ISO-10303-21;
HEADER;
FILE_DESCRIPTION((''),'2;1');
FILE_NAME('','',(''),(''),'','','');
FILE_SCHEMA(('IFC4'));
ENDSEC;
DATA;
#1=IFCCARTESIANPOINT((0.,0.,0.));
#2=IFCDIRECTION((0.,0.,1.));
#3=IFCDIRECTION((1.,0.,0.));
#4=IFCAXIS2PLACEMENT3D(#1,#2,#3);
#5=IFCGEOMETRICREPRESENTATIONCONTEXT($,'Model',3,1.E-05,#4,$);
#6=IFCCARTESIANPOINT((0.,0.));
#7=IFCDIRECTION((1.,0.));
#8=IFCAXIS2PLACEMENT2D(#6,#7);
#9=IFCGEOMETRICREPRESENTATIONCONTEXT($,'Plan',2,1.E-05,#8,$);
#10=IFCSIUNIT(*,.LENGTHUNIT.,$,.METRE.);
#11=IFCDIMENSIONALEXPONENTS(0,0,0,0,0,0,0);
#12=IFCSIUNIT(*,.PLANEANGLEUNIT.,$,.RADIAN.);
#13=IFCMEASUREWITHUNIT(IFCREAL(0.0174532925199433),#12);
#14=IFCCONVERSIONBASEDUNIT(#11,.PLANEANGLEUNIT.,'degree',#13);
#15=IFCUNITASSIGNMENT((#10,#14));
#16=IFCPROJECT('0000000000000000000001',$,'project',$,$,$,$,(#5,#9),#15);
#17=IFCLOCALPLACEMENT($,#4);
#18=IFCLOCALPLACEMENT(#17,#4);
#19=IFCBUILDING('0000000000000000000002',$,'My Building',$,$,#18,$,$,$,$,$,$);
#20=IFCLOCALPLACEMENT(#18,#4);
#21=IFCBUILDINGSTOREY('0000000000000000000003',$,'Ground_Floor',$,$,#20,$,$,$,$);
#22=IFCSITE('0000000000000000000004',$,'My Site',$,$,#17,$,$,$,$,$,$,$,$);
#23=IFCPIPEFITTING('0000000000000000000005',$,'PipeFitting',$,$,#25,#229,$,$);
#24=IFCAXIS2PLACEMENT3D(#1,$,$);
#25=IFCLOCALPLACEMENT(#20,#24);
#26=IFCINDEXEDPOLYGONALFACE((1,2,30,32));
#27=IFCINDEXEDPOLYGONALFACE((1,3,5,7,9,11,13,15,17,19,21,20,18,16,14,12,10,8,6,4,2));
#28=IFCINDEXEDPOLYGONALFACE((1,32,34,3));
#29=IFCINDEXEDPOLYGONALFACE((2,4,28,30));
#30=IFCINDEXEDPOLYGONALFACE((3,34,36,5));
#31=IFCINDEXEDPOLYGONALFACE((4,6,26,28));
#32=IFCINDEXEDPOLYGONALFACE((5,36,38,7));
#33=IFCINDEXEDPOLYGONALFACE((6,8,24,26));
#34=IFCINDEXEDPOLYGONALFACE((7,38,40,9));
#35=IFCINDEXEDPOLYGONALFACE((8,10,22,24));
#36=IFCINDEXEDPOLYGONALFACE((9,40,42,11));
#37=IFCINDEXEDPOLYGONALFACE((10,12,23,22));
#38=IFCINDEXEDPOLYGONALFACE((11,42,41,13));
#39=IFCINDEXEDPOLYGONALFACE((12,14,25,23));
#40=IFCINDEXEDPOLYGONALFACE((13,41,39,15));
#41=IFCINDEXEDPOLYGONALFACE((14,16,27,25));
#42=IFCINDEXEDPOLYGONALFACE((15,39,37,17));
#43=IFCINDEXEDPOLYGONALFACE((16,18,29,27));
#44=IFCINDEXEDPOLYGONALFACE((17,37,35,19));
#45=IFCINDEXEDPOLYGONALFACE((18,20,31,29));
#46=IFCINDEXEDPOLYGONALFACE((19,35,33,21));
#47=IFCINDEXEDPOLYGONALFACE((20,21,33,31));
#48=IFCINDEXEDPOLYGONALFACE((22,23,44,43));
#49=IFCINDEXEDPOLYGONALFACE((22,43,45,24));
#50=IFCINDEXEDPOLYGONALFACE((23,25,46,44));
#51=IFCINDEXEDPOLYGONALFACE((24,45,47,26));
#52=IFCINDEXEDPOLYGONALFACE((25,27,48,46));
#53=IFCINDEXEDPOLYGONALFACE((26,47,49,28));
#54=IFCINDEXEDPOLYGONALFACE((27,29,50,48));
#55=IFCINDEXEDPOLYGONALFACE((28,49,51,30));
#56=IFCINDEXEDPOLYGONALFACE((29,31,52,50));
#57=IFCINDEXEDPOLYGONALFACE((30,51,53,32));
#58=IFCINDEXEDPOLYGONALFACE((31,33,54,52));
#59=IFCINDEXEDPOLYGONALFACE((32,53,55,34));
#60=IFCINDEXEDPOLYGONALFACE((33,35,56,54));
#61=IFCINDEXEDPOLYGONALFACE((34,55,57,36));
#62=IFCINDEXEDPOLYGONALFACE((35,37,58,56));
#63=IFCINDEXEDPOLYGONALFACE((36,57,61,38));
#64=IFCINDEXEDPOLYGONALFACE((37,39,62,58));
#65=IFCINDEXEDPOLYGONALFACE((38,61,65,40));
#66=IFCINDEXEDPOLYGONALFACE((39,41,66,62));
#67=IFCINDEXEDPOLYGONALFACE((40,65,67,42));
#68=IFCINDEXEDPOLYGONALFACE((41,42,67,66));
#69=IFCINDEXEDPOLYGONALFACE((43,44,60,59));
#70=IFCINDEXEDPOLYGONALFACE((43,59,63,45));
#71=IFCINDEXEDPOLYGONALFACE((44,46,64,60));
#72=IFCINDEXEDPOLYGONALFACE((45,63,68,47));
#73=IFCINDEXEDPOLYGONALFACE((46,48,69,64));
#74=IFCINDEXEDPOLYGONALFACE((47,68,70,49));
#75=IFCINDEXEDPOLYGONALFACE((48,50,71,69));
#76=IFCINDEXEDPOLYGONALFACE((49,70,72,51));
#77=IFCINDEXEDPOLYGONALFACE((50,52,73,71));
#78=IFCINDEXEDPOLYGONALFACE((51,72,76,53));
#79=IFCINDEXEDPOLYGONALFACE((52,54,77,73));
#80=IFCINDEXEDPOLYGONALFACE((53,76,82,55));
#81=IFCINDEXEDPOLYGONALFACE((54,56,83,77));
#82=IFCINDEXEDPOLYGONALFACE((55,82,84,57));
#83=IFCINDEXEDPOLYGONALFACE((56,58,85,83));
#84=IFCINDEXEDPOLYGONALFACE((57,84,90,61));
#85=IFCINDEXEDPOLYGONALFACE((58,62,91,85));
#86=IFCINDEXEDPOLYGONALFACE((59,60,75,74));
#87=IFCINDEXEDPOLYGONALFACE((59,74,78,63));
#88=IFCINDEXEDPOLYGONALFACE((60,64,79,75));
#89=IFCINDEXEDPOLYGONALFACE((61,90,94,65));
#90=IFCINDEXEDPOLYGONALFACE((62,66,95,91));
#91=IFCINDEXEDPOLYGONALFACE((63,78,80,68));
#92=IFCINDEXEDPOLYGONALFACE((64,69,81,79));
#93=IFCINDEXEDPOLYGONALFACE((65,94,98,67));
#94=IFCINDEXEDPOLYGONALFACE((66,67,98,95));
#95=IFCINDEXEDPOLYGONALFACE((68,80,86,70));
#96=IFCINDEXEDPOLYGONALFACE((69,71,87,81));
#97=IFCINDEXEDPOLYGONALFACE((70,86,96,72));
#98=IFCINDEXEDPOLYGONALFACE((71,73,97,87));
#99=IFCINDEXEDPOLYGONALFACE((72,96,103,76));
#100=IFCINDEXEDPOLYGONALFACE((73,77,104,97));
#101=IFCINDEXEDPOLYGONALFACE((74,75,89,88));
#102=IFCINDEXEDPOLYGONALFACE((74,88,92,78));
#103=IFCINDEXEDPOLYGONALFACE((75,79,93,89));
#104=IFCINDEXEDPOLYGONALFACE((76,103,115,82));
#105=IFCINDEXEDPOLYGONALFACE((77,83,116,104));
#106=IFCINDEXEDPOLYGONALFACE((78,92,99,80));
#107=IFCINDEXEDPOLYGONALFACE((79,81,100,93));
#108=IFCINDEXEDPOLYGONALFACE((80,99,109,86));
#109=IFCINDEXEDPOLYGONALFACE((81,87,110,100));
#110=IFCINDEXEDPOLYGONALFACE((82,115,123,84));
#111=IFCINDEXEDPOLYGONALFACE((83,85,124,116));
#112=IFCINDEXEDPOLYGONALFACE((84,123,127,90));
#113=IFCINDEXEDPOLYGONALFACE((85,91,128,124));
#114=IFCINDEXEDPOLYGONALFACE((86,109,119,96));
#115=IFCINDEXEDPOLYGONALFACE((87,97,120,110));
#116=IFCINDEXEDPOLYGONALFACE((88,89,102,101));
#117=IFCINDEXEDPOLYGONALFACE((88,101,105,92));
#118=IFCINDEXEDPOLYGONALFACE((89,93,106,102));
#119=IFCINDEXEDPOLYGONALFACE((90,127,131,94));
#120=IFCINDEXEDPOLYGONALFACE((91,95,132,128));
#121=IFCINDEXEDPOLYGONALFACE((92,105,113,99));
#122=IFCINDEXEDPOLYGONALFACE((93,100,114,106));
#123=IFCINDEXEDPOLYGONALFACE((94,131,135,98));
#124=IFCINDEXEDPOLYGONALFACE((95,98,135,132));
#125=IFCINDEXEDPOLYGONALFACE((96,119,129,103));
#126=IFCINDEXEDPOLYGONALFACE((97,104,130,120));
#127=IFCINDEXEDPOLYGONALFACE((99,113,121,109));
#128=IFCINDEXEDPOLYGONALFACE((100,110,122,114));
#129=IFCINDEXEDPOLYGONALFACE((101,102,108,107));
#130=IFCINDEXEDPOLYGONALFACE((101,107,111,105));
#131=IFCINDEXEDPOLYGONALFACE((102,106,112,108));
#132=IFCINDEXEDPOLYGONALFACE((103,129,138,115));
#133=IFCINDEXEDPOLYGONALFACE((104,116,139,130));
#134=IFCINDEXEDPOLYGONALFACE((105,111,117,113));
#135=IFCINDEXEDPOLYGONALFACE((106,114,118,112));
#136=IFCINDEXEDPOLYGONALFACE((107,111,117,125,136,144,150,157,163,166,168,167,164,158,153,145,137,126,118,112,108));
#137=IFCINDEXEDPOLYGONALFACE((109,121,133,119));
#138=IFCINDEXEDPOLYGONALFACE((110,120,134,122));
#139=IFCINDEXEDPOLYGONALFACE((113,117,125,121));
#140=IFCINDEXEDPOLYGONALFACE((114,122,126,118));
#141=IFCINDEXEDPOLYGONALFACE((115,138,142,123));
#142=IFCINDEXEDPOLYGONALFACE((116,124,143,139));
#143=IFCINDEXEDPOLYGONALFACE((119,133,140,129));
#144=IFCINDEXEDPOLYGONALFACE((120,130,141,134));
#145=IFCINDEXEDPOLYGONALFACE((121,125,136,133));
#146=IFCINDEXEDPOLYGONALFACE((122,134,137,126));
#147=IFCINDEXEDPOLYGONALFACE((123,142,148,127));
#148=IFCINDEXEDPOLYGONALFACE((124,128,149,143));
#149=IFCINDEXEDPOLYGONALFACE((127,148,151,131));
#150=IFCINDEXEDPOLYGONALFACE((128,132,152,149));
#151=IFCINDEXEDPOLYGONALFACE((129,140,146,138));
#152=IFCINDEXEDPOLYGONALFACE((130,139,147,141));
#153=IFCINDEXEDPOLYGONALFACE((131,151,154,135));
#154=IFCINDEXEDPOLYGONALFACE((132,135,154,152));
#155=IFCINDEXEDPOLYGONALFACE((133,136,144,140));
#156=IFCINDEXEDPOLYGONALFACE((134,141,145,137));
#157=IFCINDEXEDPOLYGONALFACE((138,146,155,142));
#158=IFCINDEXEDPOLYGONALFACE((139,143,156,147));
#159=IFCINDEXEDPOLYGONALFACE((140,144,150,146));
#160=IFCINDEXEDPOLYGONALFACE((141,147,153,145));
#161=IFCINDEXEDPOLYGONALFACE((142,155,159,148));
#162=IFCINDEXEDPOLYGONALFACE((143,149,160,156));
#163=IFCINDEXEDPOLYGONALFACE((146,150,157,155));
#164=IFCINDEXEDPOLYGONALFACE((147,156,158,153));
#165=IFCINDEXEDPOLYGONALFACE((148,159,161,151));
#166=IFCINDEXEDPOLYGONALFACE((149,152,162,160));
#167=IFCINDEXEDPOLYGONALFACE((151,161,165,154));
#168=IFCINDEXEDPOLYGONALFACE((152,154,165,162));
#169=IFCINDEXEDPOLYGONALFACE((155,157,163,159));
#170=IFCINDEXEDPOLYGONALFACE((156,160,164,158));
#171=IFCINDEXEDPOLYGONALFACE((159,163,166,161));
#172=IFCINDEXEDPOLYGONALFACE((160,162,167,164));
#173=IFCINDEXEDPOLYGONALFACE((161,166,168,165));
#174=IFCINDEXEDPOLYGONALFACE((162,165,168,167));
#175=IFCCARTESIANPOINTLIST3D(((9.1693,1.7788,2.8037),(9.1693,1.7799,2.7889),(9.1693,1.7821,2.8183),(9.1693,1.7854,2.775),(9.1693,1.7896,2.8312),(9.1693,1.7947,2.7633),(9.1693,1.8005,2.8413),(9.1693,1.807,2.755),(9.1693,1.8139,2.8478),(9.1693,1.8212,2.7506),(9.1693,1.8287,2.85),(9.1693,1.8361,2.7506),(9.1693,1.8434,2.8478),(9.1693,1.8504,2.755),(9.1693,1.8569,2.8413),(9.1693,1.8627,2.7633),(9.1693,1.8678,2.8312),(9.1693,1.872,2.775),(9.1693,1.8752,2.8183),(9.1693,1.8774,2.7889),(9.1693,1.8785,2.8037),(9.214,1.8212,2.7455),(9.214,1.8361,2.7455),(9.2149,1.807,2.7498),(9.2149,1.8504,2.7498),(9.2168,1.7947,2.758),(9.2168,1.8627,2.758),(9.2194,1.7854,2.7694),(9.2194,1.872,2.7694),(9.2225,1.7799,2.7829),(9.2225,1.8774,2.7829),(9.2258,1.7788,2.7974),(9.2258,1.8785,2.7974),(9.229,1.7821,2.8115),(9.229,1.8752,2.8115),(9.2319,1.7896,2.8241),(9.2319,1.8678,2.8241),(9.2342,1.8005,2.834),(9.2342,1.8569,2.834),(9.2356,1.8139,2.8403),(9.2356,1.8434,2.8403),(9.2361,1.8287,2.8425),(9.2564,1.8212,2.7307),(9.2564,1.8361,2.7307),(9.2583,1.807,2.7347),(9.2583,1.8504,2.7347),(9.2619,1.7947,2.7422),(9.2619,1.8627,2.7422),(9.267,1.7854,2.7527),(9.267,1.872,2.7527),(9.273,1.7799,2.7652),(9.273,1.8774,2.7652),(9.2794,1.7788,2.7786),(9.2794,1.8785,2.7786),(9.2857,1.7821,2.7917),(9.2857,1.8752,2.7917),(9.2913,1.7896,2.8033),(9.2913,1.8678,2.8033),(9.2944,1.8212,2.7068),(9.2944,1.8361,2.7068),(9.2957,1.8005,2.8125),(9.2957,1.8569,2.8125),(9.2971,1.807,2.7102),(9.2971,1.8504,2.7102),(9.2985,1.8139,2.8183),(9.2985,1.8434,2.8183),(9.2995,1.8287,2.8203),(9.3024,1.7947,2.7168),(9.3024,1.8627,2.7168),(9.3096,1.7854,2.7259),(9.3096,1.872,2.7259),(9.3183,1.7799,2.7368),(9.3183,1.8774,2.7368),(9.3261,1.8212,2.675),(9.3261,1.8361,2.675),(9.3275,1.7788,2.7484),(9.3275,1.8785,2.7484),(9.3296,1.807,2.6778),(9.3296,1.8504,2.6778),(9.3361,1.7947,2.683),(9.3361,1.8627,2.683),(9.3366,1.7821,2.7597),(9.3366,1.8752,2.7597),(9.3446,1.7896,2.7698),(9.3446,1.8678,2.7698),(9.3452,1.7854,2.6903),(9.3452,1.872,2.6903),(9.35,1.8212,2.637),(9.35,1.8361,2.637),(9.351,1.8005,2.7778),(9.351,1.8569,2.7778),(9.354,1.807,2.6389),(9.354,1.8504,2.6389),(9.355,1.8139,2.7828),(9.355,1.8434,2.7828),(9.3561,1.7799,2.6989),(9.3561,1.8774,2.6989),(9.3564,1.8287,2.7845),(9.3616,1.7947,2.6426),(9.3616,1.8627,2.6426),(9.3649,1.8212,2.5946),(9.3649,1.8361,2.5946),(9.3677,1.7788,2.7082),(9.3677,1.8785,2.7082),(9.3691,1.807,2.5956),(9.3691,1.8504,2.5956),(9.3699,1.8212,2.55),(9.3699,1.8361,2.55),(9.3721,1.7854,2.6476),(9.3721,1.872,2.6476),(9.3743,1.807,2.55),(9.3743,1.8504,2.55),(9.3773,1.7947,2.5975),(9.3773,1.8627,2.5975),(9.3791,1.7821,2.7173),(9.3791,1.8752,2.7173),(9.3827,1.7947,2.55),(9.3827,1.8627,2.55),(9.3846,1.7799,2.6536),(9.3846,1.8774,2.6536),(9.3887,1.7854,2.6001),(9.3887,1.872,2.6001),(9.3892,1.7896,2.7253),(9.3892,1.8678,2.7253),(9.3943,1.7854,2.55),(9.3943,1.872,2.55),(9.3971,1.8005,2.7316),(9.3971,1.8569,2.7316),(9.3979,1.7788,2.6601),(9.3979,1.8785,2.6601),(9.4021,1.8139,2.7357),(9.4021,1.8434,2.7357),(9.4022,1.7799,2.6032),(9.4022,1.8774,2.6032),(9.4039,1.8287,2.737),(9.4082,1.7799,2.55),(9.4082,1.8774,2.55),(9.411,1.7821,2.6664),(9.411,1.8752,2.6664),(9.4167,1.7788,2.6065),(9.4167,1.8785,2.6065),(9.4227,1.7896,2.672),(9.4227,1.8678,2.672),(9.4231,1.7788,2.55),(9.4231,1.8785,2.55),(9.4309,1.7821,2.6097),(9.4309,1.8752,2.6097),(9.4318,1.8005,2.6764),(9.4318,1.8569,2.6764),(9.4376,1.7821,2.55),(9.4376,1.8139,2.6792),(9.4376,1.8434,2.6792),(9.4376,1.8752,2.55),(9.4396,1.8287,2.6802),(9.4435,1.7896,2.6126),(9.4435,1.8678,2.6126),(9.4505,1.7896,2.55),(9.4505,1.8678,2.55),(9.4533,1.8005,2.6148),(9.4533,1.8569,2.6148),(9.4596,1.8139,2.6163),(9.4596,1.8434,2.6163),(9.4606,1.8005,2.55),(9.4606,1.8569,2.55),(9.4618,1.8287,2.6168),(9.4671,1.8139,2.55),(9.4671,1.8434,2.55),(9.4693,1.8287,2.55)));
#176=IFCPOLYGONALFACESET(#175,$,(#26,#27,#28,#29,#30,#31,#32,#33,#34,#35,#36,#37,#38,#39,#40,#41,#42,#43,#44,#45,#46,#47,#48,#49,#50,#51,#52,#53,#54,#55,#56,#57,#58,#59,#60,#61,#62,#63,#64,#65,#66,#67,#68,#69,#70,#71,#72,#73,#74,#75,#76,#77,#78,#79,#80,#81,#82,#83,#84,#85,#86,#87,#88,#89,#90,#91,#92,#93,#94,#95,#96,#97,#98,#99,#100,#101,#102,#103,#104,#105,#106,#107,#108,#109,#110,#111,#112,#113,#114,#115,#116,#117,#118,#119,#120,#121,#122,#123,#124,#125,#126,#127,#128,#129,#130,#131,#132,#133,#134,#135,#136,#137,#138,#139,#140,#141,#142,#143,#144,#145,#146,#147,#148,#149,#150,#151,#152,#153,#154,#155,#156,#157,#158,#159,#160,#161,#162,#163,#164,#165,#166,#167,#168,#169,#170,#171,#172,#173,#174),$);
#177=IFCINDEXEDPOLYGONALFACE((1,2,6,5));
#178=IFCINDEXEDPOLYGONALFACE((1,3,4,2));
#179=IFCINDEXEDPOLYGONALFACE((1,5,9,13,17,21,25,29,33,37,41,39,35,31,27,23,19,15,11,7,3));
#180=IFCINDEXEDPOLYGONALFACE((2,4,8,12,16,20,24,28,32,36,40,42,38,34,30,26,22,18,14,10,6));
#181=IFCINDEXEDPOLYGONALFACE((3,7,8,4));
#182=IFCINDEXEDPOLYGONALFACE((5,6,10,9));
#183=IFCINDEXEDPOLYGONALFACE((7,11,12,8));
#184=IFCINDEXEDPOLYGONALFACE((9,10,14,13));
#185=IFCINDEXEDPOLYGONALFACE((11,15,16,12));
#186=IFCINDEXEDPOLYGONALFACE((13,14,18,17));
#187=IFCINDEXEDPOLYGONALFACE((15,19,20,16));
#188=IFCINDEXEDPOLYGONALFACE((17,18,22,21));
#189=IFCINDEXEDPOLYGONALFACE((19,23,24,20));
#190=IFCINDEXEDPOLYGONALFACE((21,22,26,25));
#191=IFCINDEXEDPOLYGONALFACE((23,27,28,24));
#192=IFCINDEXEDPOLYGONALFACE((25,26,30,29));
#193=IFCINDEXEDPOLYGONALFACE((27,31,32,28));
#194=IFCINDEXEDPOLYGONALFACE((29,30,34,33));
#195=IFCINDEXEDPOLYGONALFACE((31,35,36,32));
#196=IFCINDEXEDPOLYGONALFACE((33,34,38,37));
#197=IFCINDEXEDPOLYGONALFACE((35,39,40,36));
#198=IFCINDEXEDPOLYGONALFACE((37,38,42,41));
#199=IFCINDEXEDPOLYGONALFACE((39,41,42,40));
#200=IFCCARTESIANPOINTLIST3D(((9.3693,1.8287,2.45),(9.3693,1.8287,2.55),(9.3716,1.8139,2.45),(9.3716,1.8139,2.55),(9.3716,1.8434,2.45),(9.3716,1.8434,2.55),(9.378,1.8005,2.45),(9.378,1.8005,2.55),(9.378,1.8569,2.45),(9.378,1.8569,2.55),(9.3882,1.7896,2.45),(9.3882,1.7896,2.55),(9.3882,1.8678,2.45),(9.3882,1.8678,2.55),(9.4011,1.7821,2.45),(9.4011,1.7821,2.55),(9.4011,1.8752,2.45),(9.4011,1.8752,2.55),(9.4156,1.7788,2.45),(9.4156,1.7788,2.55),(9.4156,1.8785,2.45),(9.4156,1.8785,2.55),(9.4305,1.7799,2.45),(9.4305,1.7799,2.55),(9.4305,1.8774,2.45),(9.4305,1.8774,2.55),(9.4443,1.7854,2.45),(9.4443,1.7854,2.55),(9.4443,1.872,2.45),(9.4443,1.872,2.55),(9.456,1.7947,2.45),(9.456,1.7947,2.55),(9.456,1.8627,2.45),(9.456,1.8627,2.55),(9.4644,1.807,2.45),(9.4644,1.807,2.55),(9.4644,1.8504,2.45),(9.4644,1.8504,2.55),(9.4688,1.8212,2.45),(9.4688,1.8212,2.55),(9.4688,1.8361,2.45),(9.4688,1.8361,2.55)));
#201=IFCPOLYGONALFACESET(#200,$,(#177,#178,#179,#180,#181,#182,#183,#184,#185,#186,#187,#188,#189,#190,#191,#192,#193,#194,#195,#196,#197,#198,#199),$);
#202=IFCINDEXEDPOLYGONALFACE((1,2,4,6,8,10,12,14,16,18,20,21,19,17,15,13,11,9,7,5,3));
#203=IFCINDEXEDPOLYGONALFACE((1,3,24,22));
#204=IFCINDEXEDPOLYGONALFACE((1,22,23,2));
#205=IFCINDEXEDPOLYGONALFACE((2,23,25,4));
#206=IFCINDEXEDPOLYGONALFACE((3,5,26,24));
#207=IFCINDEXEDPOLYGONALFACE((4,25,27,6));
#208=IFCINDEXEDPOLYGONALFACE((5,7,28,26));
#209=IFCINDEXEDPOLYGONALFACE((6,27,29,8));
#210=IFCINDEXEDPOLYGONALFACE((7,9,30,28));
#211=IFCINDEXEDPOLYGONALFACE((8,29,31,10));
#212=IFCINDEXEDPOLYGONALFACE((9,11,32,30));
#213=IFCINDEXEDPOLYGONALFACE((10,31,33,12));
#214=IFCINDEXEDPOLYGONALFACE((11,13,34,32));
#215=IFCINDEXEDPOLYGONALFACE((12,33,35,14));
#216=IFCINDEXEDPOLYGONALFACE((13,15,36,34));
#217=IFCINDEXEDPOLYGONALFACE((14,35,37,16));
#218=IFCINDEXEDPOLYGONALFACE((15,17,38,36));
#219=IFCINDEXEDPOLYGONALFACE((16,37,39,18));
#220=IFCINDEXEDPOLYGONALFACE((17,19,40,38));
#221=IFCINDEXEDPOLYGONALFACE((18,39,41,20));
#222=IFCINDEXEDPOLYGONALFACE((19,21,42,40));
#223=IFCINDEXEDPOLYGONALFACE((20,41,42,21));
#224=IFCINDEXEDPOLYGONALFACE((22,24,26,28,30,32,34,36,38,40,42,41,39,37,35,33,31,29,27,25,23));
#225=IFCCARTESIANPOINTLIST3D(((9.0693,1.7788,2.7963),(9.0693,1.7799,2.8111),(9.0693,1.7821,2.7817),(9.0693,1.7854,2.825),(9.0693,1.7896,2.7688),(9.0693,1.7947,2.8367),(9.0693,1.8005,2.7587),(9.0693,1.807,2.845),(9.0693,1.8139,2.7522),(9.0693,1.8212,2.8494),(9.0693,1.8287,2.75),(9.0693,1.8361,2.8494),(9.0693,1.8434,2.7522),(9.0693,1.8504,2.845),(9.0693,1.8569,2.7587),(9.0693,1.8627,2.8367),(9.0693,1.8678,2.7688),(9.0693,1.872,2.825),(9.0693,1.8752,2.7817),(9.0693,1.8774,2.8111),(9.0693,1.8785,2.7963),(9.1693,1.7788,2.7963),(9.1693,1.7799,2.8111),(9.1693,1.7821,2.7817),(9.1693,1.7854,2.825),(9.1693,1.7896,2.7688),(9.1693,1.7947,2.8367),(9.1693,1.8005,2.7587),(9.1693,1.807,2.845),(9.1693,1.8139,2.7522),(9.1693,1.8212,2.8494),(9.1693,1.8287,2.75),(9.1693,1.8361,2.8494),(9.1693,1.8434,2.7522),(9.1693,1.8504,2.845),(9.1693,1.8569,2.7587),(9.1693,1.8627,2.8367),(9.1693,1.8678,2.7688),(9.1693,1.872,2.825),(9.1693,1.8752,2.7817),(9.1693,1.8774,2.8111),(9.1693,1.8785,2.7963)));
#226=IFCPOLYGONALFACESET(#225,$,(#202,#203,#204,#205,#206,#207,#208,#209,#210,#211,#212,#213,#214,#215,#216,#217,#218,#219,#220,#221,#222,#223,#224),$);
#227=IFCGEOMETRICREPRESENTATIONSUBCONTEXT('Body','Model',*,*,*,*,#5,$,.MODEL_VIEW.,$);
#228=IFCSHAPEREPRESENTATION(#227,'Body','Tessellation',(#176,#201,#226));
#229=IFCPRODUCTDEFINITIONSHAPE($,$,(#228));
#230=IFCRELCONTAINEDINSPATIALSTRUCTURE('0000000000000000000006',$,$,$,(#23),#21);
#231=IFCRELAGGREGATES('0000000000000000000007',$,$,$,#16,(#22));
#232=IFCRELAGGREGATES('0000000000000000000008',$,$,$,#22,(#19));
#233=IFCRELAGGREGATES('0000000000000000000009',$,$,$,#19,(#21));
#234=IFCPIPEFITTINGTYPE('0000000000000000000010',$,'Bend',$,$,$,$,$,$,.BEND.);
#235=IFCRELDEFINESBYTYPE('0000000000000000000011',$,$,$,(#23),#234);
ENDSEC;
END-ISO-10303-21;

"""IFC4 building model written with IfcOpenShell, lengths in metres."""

from ifc_helpers import new_model, entity, si_unit, converted_unit, frame, origin_with_axes, origin_2d_with_axis, place, context, subcontext, project, spatial, circle, extrude, source, transform, mapped, type_object, type_shapes, element, save


model = new_model("IFC4")

# Units and contexts
model_context = context("Model", 3, precision=1e-05, world=origin_with_axes())
plan_context = context("Plan", 2, precision=1e-05, world=origin_2d_with_axis())
body_context = subcontext(model_context, "Body", "Model", "MODEL_VIEW")
ifc_project = project(units=[si_unit("LENGTHUNIT", "METRE"), converted_unit("PLANEANGLEUNIT", "degree", entity("IfcReal", 0.0174532925199433), si_unit("PLANEANGLEUNIT", "RADIAN"), dimensions=[0, 0, 0, 0, 0, 0, 0])], contexts=[model_context, plan_context])

# Site, building, storey
site_placement = place(None, origin_with_axes())
site = spatial("IfcSite", under=ifc_project, at=site_placement, Name="My Site")
building_placement = place(site_placement, origin_with_axes())
building = spatial("IfcBuilding", under=site, at=building_placement, Name="My Building")
storey_placement = place(building_placement, origin_with_axes())
storey = spatial("IfcBuildingStorey", under=building, at=storey_placement, Name="Ground_Floor")

# Pipe fitting
pipe_fitting_type = type_object("IfcPipeFittingType", Name="Bend", PredefinedType="BEND")
shared_shape = source(origin_with_axes(), body_context, "Body", "SolidModel", [
    entity("IfcSweptDiskSolid", entity("IfcIndexedPolyCurve", entity("IfcCartesianPointList3D", [[0.0, 0.0, -0.1], [0.0732, 0.0, -0.2768], [0.25, 0.0, -0.35]]), [entity("IfcArcIndex", [1, 2, 3])]), 0.05),
    extrude(circle(Radius=0.05), origin_with_axes(), (0.0, 0.0, -1.0), 0.1),
    extrude(circle(Radius=0.05), frame((0.25, 0.0, -0.35), z_axis=(1.0, 0.0, 0.0), x_axis=(0.0, 0.0, 1.0)), (0.0, 0.0, 1.0), 0.1),
])
type_shapes(pipe_fitting_type, [shared_shape])
for number, where, z_axis, x_axis, name in (
    (1, (9.4193, 1.8287, 2.45), (0.0, 0.0, -1.0), (-1.0, 0.0, 0.0), "PipeFitting"),
):
    element("IfcPipeFitting", number, at=place(storey_placement, frame(where, z_axis=z_axis, x_axis=x_axis)), inside=storey, type_object=pipe_fitting_type, Name=name, context=body_context, shape_type="MappedRepresentation", body=[
        mapped(shared_shape, transform((0.0, 0.0, 0.0), x_axis=(1.0, 0.0, 0.0), y_axis=(0.0, 1.0, 0.0), z_axis=(0.0, 0.0, 1.0), scale=1.0)),
    ])

save(model, "model.ifc")
